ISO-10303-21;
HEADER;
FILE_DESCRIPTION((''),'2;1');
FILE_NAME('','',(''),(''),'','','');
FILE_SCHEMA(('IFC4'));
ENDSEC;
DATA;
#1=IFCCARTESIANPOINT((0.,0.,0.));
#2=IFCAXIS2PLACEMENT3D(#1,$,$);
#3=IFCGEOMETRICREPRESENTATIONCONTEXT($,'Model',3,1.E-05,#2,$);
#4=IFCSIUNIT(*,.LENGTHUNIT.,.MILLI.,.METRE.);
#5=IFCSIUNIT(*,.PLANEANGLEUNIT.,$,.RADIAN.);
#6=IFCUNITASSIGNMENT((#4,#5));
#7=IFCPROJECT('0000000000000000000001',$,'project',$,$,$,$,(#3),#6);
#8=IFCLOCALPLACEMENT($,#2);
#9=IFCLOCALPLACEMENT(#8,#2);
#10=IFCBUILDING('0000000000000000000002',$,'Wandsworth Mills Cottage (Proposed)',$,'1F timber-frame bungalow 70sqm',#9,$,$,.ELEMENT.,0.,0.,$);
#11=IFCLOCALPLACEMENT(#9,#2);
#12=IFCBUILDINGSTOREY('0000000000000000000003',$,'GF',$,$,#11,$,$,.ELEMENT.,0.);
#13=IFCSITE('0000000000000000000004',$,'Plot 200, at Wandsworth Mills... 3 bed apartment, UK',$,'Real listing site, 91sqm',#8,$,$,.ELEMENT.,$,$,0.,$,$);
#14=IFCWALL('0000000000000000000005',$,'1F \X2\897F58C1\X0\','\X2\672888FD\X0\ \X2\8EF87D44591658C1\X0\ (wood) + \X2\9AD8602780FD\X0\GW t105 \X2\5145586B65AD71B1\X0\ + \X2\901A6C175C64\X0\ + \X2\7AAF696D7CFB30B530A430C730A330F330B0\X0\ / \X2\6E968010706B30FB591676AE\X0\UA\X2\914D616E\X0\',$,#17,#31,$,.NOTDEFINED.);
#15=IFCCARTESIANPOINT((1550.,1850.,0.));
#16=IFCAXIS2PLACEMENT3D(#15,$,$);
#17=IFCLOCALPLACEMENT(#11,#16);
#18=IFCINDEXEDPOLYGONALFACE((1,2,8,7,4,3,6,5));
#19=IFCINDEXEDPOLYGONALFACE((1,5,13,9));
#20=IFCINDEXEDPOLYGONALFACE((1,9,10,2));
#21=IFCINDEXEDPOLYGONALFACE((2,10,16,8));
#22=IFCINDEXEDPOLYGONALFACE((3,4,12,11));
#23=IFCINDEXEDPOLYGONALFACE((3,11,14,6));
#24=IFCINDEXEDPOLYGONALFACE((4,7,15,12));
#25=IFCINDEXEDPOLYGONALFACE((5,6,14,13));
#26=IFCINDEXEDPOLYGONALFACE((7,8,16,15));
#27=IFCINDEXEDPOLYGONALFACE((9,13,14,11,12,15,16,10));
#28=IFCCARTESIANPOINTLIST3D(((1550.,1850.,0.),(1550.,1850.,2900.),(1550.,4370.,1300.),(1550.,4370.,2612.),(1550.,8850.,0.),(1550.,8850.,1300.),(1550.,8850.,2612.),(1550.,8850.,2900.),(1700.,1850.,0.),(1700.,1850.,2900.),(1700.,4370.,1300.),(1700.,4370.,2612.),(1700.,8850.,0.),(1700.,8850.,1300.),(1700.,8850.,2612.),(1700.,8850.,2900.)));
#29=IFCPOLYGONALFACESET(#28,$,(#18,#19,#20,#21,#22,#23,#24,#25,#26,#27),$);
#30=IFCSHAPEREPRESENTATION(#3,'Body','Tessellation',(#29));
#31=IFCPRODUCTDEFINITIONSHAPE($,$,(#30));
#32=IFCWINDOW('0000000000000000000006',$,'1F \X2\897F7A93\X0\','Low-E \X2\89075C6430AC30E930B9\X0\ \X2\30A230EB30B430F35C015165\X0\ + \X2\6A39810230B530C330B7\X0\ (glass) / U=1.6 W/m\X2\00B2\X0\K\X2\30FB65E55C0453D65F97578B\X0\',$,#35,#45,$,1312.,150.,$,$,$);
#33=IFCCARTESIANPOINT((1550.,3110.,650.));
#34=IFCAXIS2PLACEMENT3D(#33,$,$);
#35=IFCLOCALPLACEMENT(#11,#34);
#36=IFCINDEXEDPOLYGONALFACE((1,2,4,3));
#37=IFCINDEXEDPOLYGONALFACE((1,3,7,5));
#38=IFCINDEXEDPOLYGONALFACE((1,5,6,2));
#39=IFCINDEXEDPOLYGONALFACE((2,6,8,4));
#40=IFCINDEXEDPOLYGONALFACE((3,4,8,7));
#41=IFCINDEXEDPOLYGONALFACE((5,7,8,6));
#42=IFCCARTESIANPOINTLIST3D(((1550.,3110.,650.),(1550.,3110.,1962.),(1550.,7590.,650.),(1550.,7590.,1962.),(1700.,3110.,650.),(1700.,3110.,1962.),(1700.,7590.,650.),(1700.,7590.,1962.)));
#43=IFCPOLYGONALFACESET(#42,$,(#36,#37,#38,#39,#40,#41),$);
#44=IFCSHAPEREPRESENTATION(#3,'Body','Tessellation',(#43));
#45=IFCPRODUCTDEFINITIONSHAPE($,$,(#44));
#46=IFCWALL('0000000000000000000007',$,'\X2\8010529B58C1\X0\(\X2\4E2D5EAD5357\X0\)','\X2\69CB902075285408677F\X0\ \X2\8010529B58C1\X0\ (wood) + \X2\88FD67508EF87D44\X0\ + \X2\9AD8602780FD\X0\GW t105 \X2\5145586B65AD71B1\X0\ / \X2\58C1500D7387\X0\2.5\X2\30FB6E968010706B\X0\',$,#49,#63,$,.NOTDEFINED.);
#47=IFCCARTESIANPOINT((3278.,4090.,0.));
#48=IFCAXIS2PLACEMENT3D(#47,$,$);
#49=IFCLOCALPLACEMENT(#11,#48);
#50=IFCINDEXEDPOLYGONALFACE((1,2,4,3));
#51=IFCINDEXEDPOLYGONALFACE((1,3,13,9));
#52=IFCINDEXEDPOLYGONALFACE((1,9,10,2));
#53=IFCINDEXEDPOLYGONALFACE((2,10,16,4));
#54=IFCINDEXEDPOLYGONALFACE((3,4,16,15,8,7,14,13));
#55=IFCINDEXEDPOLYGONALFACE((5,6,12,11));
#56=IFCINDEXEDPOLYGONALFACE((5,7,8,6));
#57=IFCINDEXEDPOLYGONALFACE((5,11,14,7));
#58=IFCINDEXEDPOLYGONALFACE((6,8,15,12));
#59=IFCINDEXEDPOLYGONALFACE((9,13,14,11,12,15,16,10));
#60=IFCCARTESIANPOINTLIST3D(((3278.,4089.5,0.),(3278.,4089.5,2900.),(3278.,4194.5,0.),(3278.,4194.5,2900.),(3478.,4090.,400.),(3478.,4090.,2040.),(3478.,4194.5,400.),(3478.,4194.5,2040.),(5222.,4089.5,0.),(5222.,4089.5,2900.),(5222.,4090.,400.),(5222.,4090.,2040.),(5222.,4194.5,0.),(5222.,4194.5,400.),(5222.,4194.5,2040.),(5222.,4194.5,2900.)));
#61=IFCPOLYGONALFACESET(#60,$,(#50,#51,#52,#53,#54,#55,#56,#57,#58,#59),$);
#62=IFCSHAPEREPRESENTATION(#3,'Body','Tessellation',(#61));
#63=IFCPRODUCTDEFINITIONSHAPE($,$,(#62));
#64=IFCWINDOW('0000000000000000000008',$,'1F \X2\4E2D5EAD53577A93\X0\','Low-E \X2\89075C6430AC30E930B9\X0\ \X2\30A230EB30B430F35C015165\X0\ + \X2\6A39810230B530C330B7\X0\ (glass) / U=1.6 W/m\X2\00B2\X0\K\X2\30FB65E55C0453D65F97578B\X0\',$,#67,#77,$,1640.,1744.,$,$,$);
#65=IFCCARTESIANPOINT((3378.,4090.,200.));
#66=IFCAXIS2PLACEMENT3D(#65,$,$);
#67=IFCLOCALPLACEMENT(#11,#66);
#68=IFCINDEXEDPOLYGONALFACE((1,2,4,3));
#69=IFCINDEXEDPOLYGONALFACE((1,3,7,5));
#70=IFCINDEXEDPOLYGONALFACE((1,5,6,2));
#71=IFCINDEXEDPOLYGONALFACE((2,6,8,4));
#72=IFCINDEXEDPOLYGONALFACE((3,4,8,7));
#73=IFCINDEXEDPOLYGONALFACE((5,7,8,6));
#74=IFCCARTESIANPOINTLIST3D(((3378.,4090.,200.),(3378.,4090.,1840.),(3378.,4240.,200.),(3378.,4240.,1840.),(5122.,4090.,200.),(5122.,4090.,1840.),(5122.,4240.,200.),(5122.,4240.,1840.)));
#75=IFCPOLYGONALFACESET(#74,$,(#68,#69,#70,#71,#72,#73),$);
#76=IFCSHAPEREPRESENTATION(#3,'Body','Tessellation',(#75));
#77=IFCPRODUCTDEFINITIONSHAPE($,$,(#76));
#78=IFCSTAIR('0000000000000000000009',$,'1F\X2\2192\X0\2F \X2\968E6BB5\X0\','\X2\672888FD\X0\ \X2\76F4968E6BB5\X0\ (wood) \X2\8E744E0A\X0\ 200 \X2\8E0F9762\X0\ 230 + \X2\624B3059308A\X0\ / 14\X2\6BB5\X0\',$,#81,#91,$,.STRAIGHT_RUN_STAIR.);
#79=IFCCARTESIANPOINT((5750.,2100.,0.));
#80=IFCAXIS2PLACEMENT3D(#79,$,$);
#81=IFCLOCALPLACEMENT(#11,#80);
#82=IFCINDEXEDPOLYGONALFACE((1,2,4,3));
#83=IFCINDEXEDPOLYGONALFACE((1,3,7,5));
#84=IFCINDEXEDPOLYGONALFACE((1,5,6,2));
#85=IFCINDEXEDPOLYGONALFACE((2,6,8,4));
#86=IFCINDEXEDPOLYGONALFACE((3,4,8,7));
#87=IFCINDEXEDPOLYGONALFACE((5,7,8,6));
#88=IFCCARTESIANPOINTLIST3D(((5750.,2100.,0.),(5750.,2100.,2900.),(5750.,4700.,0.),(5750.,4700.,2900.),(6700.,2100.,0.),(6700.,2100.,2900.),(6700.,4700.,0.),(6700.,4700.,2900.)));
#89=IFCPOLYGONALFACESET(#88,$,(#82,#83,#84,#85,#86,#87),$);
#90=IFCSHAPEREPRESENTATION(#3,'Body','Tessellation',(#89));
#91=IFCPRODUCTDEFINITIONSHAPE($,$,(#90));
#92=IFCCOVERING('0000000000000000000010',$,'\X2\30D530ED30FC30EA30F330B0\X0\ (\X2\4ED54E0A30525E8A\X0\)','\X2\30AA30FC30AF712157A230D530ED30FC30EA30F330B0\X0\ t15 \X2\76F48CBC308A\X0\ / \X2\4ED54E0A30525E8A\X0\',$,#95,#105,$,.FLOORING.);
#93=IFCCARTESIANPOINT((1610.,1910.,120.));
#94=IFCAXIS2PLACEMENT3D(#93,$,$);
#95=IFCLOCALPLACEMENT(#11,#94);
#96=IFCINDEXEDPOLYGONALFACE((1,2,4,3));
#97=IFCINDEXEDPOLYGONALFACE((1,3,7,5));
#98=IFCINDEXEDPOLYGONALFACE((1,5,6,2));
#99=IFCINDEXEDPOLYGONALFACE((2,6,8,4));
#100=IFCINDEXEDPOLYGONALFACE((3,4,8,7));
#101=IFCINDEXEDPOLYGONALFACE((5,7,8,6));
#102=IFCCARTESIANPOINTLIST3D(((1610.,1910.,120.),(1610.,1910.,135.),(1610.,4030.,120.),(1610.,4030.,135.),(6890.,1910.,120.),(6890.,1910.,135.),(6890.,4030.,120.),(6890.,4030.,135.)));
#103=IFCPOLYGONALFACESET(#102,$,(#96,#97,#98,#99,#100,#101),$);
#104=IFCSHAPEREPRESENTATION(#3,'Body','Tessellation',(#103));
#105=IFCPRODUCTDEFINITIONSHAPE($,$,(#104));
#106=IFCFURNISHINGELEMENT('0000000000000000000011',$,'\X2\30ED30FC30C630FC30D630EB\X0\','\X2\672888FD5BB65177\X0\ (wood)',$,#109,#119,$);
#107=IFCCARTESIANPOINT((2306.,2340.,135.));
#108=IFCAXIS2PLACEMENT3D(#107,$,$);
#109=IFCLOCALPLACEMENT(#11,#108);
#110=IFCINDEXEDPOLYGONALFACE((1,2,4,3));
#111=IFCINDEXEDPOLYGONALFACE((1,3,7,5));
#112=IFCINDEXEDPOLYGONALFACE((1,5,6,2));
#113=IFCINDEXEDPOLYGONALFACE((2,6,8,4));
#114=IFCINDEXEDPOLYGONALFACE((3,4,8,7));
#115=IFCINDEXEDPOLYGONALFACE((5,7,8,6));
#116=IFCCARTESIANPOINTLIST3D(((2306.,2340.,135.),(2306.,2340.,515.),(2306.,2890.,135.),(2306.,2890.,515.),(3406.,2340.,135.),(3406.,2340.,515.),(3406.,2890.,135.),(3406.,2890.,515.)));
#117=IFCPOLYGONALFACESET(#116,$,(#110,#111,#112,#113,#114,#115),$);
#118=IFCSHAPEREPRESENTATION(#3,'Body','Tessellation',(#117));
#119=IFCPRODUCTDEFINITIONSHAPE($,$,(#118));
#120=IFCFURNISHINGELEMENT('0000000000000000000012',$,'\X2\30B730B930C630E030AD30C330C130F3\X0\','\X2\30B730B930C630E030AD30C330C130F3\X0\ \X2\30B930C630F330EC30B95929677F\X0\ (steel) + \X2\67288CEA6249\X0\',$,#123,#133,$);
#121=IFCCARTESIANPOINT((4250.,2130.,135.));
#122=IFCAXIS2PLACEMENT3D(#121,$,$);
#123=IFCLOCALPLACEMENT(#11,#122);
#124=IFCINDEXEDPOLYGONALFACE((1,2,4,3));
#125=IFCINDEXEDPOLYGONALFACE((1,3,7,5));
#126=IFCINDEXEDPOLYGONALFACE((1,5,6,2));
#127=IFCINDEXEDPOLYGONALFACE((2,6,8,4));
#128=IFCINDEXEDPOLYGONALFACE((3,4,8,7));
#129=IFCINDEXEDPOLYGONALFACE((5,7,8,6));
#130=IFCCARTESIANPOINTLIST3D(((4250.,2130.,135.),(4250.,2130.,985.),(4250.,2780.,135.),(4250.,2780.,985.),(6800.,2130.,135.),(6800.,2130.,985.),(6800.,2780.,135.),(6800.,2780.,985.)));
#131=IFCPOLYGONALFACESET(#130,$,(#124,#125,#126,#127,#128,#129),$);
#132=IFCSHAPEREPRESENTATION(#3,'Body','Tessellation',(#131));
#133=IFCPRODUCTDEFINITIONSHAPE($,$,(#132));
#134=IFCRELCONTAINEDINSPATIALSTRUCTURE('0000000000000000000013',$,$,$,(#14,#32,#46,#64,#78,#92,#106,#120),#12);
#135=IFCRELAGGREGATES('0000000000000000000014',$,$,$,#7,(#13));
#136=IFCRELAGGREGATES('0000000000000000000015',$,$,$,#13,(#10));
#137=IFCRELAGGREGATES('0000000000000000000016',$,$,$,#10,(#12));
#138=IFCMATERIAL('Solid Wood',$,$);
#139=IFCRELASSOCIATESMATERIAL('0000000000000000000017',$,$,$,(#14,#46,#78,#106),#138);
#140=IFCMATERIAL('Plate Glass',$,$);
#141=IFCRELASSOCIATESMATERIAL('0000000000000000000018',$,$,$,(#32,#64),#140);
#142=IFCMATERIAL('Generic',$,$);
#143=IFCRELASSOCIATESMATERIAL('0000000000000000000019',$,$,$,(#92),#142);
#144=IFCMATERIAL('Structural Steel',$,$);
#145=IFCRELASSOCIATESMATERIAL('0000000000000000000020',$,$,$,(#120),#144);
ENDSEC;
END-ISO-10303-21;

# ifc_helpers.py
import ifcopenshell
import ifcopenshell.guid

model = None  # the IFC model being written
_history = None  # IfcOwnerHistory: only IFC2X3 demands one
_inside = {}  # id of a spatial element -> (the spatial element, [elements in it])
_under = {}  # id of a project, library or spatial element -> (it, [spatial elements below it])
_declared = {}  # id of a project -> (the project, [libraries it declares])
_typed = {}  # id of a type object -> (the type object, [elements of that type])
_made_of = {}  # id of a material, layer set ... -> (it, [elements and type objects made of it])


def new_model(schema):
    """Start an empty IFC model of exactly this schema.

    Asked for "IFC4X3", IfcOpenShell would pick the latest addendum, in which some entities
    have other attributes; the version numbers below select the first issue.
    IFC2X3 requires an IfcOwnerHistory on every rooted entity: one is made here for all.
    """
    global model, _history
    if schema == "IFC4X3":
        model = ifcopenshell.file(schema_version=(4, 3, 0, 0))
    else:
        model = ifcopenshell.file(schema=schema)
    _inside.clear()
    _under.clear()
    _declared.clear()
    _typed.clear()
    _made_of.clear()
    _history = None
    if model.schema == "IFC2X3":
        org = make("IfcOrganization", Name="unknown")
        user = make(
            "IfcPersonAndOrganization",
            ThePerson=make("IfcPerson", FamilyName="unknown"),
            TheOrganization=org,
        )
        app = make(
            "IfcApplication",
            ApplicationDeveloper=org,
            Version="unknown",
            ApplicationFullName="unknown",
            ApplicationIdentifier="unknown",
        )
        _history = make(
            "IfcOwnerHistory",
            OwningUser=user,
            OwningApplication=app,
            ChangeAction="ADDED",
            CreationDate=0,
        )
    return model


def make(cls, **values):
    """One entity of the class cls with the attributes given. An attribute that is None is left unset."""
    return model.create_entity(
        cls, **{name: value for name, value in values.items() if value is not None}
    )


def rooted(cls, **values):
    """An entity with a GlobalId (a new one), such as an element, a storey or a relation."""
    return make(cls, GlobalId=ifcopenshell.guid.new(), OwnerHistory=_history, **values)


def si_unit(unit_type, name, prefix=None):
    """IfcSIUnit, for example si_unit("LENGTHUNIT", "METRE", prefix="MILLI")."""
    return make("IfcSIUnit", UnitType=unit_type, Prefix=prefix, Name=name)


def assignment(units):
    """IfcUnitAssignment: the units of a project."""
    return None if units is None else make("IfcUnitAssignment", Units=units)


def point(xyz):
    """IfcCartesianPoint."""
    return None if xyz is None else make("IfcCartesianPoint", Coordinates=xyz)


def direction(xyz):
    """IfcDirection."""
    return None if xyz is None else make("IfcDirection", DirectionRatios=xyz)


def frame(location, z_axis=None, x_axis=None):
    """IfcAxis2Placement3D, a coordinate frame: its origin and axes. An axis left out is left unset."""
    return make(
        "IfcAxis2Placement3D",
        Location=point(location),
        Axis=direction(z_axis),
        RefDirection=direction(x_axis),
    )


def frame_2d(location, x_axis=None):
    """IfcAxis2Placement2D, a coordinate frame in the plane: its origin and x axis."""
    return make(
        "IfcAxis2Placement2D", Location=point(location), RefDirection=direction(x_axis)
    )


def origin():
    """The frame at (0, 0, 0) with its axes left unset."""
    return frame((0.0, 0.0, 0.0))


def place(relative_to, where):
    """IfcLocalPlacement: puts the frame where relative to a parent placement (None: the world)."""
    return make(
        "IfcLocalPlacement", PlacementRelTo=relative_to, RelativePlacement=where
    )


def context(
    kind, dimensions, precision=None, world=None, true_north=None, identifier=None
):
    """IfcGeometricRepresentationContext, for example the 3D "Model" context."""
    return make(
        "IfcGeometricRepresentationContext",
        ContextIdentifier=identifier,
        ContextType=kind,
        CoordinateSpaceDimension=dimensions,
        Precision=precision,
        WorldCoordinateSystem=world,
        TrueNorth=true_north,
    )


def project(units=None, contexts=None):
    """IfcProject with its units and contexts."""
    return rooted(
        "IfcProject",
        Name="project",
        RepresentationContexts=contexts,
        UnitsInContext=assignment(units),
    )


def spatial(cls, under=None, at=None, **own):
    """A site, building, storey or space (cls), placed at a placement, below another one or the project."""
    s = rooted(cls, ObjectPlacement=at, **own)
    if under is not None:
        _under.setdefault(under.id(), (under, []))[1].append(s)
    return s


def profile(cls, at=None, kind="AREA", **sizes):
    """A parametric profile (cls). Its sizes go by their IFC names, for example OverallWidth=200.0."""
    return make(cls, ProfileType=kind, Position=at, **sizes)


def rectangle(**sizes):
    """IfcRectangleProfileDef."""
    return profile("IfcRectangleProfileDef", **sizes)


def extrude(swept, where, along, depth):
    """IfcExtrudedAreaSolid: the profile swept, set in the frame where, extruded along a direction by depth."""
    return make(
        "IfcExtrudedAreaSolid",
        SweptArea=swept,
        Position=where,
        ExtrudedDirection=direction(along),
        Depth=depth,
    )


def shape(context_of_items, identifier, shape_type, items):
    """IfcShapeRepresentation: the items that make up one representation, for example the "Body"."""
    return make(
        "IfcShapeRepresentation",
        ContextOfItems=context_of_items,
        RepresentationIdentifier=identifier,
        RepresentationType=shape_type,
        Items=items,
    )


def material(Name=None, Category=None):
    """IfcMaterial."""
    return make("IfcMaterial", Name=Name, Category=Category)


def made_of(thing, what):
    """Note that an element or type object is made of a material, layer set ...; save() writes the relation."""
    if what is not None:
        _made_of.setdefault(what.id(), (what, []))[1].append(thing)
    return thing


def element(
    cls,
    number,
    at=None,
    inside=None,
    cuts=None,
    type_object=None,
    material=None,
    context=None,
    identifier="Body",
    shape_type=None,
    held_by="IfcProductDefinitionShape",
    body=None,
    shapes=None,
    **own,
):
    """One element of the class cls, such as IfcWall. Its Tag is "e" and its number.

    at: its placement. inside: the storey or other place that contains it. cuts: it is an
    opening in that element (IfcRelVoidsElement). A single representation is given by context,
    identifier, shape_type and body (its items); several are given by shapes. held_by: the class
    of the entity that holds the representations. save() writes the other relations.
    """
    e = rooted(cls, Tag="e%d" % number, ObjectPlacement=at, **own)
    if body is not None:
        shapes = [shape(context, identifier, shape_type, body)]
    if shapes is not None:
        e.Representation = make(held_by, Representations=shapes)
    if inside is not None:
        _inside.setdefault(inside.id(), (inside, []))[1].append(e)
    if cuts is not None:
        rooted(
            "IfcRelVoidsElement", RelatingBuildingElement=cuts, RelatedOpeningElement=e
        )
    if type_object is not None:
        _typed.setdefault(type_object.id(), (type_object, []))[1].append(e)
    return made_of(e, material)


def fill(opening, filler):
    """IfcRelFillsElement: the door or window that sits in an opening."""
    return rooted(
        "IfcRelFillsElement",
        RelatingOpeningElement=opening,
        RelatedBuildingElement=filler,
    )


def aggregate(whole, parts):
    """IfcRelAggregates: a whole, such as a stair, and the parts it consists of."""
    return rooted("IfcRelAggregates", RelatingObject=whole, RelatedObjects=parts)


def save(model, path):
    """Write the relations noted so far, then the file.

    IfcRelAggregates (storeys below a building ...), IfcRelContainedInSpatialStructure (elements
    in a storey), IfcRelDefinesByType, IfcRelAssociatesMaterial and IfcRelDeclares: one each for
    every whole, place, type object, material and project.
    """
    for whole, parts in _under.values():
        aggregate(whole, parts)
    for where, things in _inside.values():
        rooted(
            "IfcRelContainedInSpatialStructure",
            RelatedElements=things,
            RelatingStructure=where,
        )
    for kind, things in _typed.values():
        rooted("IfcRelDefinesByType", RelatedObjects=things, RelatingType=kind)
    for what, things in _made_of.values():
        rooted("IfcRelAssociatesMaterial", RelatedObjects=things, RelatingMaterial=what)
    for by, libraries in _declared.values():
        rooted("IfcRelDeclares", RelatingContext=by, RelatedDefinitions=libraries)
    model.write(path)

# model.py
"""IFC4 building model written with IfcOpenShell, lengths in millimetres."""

from ifc_helpers import new_model, si_unit, frame, frame_2d, origin, place, context, project, spatial, rectangle, extrude, material, element, fill, save


model = new_model("IFC4")

# Units and contexts
model_context = context("Model", 3, precision=1e-05, world=origin())
ifc_project = project(units=[si_unit("LENGTHUNIT", "METRE", prefix="MILLI"), si_unit("PLANEANGLEUNIT", "RADIAN")], contexts=[model_context])

# Site, building, storey
site_placement = place(None, origin())
site = spatial("IfcSite", under=ifc_project, at=site_placement, Name="Plot 200, at Wandsworth Mills... 3 bed apartment, UK", ObjectType="Real listing site, 91sqm", CompositionType="ELEMENT", RefElevation=0.0)
building_placement = place(site_placement, origin())
building = spatial("IfcBuilding", under=site, at=building_placement, Name="Wandsworth Mills Cottage (Proposed)", ObjectType="1F timber-frame bungalow 70sqm", CompositionType="ELEMENT", ElevationOfRefHeight=0.0, ElevationOfTerrain=0.0)
storey_placement = place(building_placement, origin())
storey = spatial("IfcBuildingStorey", under=building, at=storey_placement, Name="GF", CompositionType="ELEMENT", Elevation=0.0)

# Shared definitions
ifc_material_1 = material(Name="Solid Wood")

# Shared definitions
ifc_material_2 = material(Name="Plate Glass")
ifc_material_3 = material(Name="Generic")

# Walls, openings, windows
wall_1_placement = place(storey_placement, frame((1550.0, 1850.0, 0.0)))
wall_1 = element("IfcWall", 1, at=wall_1_placement, inside=storey, material=ifc_material_1, Name="1F 西壁", Description="木製 軸組外壁 (wood) + 高性能GW t105 充填断熱 + 通気層 + 窯業系サイディング / 準耐火・外皮UA配慮", PredefinedType="NOTDEFINED", context=model_context, shape_type="SweptSolid", body=[
    extrude(rectangle(XDim=150.0, YDim=7000.0, at=frame_2d((75.0, 3500.0))), frame((1550.0, 1850.0, 0.0)), (0.0, 0.0, 1.0), 2900.0),
])
opening_1_placement = place(storey_placement, frame((1550.0, 3110.0, 650.0)))
opening_1 = element("IfcOpeningElement", 2, at=opening_1_placement, cuts=wall_1, PredefinedType="NOTDEFINED", context=model_context, shape_type="SweptSolid", body=[
    extrude(rectangle(XDim=150.0, YDim=4480.0, at=frame_2d((75.0, 2240.0))), frame((1550.0, 3110.0, 650.0)), (0.0, 0.0, 1.0), 1312.0),
])
window_1_placement = place(storey_placement, frame((1550.0, 3110.0, 650.0)))
window_1 = element("IfcWindow", 3, at=window_1_placement, inside=storey, material=ifc_material_2, Name="1F 西窓", Description="Low-E 複層ガラス アルゴン封入 + 樹脂サッシ (glass) / U=1.6 W/m²K・日射取得型", OverallHeight=1312.0, OverallWidth=150.0, context=model_context, shape_type="SweptSolid", body=[
    extrude(rectangle(XDim=150.0, YDim=4480.0, at=frame_2d((75.0, 2240.0))), frame((1550.0, 3110.0, 650.0)), (0.0, 0.0, 1.0), 1312.0),
])
fill(opening_1, window_1)
wall_2_placement = place(storey_placement, frame((3278.0, 4090.0, 0.0)))
wall_2 = element("IfcWall", 4, at=wall_2_placement, inside=storey, material=ifc_material_1, Name="耐力壁(中庭南)", Description="構造用合板 耐力壁 (wood) + 製材軸組 + 高性能GW t105 充填断熱 / 壁倍率2.5・準耐火", PredefinedType="NOTDEFINED", context=model_context, shape_type="SweptSolid", body=[
    extrude(rectangle(XDim=1944.0, YDim=105.0, at=frame_2d((972.0, 52.0))), frame((3278.0, 4090.0, 0.0)), (0.0, 0.0, 1.0), 2900.0),
])
opening_2_placement = place(storey_placement, frame((3378.0, 4090.0, 200.0)))
opening_2 = element("IfcOpeningElement", 5, at=opening_2_placement, cuts=wall_2, PredefinedType="NOTDEFINED", context=model_context, shape_type="SweptSolid", body=[
    extrude(rectangle(XDim=1744.0, YDim=150.0, at=frame_2d((872.0, 75.0))), frame((3378.0, 4090.0, 200.0)), (0.0, 0.0, 1.0), 1640.0),
])
window_2_placement = place(storey_placement, frame((3378.0, 4090.0, 200.0)))
window_2 = element("IfcWindow", 6, at=window_2_placement, inside=storey, material=ifc_material_2, Name="1F 中庭南窓", Description="Low-E 複層ガラス アルゴン封入 + 樹脂サッシ (glass) / U=1.6 W/m²K・日射取得型", OverallHeight=1640.0, OverallWidth=1744.0, context=model_context, shape_type="SweptSolid", body=[
    extrude(rectangle(XDim=1744.0, YDim=150.0, at=frame_2d((872.0, 75.0))), frame((3378.0, 4090.0, 200.0)), (0.0, 0.0, 1.0), 1640.0),
])
fill(opening_2, window_2)

# Stair
stair_placement = place(storey_placement, frame((5750.0, 2100.0, 0.0)))
element("IfcStair", 7, at=stair_placement, inside=storey, material=ifc_material_1, Name="1F→2F 階段", Description="木製 直階段 (wood) 蹴上 200 踏面 230 + 手すり / 14段", PredefinedType="STRAIGHT_RUN_STAIR", context=model_context, shape_type="SweptSolid", body=[
    extrude(rectangle(XDim=950.0, YDim=2600.0, at=frame_2d((475.0, 1300.0))), frame((5750.0, 2100.0, 0.0)), (0.0, 0.0, 1.0), 2900.0),
])

# Covering
covering_placement = place(storey_placement, frame((1610.0, 1910.0, 120.0)))
element("IfcCovering", 8, at=covering_placement, inside=storey, material=ifc_material_3, Name="フローリング (仕上げ床)", Description="オーク無垢フローリング t15 直貼り / 仕上げ床", PredefinedType="FLOORING", context=model_context, shape_type="SweptSolid", body=[
    extrude(rectangle(XDim=5280.0, YDim=2120.0, at=frame_2d((2640.0, 1060.0))), frame((1610.0, 1910.0, 120.0)), (0.0, 0.0, 1.0), 15.0),
])

# Furnishing elements
furnishing_1_placement = place(storey_placement, frame((2306.0, 2340.0, 135.0)))
element("IfcFurnishingElement", 9, at=furnishing_1_placement, inside=storey, material=ifc_material_1, Name="ローテーブル", Description="木製家具 (wood)", context=model_context, shape_type="SweptSolid", body=[
    extrude(rectangle(XDim=1100.0, YDim=550.0, at=frame_2d((550.0, 275.0))), frame((2306.0, 2340.0, 135.0)), (0.0, 0.0, 1.0), 380.0),
])
ifc_material_4 = material(Name="Structural Steel")
furnishing_2_placement = place(storey_placement, frame((4250.0, 2130.0, 135.0)))
element("IfcFurnishingElement", 10, at=furnishing_2_placement, inside=storey, material=ifc_material_4, Name="システムキッチン", Description="システムキッチン ステンレス天板 (steel) + 木質扉", context=model_context, shape_type="SweptSolid", body=[
    extrude(rectangle(XDim=2550.0, YDim=650.0, at=frame_2d((1275.0, 325.0))), frame((4250.0, 2130.0, 135.0)), (0.0, 0.0, 1.0), 850.0),
])

save(model, "model.ifc")
